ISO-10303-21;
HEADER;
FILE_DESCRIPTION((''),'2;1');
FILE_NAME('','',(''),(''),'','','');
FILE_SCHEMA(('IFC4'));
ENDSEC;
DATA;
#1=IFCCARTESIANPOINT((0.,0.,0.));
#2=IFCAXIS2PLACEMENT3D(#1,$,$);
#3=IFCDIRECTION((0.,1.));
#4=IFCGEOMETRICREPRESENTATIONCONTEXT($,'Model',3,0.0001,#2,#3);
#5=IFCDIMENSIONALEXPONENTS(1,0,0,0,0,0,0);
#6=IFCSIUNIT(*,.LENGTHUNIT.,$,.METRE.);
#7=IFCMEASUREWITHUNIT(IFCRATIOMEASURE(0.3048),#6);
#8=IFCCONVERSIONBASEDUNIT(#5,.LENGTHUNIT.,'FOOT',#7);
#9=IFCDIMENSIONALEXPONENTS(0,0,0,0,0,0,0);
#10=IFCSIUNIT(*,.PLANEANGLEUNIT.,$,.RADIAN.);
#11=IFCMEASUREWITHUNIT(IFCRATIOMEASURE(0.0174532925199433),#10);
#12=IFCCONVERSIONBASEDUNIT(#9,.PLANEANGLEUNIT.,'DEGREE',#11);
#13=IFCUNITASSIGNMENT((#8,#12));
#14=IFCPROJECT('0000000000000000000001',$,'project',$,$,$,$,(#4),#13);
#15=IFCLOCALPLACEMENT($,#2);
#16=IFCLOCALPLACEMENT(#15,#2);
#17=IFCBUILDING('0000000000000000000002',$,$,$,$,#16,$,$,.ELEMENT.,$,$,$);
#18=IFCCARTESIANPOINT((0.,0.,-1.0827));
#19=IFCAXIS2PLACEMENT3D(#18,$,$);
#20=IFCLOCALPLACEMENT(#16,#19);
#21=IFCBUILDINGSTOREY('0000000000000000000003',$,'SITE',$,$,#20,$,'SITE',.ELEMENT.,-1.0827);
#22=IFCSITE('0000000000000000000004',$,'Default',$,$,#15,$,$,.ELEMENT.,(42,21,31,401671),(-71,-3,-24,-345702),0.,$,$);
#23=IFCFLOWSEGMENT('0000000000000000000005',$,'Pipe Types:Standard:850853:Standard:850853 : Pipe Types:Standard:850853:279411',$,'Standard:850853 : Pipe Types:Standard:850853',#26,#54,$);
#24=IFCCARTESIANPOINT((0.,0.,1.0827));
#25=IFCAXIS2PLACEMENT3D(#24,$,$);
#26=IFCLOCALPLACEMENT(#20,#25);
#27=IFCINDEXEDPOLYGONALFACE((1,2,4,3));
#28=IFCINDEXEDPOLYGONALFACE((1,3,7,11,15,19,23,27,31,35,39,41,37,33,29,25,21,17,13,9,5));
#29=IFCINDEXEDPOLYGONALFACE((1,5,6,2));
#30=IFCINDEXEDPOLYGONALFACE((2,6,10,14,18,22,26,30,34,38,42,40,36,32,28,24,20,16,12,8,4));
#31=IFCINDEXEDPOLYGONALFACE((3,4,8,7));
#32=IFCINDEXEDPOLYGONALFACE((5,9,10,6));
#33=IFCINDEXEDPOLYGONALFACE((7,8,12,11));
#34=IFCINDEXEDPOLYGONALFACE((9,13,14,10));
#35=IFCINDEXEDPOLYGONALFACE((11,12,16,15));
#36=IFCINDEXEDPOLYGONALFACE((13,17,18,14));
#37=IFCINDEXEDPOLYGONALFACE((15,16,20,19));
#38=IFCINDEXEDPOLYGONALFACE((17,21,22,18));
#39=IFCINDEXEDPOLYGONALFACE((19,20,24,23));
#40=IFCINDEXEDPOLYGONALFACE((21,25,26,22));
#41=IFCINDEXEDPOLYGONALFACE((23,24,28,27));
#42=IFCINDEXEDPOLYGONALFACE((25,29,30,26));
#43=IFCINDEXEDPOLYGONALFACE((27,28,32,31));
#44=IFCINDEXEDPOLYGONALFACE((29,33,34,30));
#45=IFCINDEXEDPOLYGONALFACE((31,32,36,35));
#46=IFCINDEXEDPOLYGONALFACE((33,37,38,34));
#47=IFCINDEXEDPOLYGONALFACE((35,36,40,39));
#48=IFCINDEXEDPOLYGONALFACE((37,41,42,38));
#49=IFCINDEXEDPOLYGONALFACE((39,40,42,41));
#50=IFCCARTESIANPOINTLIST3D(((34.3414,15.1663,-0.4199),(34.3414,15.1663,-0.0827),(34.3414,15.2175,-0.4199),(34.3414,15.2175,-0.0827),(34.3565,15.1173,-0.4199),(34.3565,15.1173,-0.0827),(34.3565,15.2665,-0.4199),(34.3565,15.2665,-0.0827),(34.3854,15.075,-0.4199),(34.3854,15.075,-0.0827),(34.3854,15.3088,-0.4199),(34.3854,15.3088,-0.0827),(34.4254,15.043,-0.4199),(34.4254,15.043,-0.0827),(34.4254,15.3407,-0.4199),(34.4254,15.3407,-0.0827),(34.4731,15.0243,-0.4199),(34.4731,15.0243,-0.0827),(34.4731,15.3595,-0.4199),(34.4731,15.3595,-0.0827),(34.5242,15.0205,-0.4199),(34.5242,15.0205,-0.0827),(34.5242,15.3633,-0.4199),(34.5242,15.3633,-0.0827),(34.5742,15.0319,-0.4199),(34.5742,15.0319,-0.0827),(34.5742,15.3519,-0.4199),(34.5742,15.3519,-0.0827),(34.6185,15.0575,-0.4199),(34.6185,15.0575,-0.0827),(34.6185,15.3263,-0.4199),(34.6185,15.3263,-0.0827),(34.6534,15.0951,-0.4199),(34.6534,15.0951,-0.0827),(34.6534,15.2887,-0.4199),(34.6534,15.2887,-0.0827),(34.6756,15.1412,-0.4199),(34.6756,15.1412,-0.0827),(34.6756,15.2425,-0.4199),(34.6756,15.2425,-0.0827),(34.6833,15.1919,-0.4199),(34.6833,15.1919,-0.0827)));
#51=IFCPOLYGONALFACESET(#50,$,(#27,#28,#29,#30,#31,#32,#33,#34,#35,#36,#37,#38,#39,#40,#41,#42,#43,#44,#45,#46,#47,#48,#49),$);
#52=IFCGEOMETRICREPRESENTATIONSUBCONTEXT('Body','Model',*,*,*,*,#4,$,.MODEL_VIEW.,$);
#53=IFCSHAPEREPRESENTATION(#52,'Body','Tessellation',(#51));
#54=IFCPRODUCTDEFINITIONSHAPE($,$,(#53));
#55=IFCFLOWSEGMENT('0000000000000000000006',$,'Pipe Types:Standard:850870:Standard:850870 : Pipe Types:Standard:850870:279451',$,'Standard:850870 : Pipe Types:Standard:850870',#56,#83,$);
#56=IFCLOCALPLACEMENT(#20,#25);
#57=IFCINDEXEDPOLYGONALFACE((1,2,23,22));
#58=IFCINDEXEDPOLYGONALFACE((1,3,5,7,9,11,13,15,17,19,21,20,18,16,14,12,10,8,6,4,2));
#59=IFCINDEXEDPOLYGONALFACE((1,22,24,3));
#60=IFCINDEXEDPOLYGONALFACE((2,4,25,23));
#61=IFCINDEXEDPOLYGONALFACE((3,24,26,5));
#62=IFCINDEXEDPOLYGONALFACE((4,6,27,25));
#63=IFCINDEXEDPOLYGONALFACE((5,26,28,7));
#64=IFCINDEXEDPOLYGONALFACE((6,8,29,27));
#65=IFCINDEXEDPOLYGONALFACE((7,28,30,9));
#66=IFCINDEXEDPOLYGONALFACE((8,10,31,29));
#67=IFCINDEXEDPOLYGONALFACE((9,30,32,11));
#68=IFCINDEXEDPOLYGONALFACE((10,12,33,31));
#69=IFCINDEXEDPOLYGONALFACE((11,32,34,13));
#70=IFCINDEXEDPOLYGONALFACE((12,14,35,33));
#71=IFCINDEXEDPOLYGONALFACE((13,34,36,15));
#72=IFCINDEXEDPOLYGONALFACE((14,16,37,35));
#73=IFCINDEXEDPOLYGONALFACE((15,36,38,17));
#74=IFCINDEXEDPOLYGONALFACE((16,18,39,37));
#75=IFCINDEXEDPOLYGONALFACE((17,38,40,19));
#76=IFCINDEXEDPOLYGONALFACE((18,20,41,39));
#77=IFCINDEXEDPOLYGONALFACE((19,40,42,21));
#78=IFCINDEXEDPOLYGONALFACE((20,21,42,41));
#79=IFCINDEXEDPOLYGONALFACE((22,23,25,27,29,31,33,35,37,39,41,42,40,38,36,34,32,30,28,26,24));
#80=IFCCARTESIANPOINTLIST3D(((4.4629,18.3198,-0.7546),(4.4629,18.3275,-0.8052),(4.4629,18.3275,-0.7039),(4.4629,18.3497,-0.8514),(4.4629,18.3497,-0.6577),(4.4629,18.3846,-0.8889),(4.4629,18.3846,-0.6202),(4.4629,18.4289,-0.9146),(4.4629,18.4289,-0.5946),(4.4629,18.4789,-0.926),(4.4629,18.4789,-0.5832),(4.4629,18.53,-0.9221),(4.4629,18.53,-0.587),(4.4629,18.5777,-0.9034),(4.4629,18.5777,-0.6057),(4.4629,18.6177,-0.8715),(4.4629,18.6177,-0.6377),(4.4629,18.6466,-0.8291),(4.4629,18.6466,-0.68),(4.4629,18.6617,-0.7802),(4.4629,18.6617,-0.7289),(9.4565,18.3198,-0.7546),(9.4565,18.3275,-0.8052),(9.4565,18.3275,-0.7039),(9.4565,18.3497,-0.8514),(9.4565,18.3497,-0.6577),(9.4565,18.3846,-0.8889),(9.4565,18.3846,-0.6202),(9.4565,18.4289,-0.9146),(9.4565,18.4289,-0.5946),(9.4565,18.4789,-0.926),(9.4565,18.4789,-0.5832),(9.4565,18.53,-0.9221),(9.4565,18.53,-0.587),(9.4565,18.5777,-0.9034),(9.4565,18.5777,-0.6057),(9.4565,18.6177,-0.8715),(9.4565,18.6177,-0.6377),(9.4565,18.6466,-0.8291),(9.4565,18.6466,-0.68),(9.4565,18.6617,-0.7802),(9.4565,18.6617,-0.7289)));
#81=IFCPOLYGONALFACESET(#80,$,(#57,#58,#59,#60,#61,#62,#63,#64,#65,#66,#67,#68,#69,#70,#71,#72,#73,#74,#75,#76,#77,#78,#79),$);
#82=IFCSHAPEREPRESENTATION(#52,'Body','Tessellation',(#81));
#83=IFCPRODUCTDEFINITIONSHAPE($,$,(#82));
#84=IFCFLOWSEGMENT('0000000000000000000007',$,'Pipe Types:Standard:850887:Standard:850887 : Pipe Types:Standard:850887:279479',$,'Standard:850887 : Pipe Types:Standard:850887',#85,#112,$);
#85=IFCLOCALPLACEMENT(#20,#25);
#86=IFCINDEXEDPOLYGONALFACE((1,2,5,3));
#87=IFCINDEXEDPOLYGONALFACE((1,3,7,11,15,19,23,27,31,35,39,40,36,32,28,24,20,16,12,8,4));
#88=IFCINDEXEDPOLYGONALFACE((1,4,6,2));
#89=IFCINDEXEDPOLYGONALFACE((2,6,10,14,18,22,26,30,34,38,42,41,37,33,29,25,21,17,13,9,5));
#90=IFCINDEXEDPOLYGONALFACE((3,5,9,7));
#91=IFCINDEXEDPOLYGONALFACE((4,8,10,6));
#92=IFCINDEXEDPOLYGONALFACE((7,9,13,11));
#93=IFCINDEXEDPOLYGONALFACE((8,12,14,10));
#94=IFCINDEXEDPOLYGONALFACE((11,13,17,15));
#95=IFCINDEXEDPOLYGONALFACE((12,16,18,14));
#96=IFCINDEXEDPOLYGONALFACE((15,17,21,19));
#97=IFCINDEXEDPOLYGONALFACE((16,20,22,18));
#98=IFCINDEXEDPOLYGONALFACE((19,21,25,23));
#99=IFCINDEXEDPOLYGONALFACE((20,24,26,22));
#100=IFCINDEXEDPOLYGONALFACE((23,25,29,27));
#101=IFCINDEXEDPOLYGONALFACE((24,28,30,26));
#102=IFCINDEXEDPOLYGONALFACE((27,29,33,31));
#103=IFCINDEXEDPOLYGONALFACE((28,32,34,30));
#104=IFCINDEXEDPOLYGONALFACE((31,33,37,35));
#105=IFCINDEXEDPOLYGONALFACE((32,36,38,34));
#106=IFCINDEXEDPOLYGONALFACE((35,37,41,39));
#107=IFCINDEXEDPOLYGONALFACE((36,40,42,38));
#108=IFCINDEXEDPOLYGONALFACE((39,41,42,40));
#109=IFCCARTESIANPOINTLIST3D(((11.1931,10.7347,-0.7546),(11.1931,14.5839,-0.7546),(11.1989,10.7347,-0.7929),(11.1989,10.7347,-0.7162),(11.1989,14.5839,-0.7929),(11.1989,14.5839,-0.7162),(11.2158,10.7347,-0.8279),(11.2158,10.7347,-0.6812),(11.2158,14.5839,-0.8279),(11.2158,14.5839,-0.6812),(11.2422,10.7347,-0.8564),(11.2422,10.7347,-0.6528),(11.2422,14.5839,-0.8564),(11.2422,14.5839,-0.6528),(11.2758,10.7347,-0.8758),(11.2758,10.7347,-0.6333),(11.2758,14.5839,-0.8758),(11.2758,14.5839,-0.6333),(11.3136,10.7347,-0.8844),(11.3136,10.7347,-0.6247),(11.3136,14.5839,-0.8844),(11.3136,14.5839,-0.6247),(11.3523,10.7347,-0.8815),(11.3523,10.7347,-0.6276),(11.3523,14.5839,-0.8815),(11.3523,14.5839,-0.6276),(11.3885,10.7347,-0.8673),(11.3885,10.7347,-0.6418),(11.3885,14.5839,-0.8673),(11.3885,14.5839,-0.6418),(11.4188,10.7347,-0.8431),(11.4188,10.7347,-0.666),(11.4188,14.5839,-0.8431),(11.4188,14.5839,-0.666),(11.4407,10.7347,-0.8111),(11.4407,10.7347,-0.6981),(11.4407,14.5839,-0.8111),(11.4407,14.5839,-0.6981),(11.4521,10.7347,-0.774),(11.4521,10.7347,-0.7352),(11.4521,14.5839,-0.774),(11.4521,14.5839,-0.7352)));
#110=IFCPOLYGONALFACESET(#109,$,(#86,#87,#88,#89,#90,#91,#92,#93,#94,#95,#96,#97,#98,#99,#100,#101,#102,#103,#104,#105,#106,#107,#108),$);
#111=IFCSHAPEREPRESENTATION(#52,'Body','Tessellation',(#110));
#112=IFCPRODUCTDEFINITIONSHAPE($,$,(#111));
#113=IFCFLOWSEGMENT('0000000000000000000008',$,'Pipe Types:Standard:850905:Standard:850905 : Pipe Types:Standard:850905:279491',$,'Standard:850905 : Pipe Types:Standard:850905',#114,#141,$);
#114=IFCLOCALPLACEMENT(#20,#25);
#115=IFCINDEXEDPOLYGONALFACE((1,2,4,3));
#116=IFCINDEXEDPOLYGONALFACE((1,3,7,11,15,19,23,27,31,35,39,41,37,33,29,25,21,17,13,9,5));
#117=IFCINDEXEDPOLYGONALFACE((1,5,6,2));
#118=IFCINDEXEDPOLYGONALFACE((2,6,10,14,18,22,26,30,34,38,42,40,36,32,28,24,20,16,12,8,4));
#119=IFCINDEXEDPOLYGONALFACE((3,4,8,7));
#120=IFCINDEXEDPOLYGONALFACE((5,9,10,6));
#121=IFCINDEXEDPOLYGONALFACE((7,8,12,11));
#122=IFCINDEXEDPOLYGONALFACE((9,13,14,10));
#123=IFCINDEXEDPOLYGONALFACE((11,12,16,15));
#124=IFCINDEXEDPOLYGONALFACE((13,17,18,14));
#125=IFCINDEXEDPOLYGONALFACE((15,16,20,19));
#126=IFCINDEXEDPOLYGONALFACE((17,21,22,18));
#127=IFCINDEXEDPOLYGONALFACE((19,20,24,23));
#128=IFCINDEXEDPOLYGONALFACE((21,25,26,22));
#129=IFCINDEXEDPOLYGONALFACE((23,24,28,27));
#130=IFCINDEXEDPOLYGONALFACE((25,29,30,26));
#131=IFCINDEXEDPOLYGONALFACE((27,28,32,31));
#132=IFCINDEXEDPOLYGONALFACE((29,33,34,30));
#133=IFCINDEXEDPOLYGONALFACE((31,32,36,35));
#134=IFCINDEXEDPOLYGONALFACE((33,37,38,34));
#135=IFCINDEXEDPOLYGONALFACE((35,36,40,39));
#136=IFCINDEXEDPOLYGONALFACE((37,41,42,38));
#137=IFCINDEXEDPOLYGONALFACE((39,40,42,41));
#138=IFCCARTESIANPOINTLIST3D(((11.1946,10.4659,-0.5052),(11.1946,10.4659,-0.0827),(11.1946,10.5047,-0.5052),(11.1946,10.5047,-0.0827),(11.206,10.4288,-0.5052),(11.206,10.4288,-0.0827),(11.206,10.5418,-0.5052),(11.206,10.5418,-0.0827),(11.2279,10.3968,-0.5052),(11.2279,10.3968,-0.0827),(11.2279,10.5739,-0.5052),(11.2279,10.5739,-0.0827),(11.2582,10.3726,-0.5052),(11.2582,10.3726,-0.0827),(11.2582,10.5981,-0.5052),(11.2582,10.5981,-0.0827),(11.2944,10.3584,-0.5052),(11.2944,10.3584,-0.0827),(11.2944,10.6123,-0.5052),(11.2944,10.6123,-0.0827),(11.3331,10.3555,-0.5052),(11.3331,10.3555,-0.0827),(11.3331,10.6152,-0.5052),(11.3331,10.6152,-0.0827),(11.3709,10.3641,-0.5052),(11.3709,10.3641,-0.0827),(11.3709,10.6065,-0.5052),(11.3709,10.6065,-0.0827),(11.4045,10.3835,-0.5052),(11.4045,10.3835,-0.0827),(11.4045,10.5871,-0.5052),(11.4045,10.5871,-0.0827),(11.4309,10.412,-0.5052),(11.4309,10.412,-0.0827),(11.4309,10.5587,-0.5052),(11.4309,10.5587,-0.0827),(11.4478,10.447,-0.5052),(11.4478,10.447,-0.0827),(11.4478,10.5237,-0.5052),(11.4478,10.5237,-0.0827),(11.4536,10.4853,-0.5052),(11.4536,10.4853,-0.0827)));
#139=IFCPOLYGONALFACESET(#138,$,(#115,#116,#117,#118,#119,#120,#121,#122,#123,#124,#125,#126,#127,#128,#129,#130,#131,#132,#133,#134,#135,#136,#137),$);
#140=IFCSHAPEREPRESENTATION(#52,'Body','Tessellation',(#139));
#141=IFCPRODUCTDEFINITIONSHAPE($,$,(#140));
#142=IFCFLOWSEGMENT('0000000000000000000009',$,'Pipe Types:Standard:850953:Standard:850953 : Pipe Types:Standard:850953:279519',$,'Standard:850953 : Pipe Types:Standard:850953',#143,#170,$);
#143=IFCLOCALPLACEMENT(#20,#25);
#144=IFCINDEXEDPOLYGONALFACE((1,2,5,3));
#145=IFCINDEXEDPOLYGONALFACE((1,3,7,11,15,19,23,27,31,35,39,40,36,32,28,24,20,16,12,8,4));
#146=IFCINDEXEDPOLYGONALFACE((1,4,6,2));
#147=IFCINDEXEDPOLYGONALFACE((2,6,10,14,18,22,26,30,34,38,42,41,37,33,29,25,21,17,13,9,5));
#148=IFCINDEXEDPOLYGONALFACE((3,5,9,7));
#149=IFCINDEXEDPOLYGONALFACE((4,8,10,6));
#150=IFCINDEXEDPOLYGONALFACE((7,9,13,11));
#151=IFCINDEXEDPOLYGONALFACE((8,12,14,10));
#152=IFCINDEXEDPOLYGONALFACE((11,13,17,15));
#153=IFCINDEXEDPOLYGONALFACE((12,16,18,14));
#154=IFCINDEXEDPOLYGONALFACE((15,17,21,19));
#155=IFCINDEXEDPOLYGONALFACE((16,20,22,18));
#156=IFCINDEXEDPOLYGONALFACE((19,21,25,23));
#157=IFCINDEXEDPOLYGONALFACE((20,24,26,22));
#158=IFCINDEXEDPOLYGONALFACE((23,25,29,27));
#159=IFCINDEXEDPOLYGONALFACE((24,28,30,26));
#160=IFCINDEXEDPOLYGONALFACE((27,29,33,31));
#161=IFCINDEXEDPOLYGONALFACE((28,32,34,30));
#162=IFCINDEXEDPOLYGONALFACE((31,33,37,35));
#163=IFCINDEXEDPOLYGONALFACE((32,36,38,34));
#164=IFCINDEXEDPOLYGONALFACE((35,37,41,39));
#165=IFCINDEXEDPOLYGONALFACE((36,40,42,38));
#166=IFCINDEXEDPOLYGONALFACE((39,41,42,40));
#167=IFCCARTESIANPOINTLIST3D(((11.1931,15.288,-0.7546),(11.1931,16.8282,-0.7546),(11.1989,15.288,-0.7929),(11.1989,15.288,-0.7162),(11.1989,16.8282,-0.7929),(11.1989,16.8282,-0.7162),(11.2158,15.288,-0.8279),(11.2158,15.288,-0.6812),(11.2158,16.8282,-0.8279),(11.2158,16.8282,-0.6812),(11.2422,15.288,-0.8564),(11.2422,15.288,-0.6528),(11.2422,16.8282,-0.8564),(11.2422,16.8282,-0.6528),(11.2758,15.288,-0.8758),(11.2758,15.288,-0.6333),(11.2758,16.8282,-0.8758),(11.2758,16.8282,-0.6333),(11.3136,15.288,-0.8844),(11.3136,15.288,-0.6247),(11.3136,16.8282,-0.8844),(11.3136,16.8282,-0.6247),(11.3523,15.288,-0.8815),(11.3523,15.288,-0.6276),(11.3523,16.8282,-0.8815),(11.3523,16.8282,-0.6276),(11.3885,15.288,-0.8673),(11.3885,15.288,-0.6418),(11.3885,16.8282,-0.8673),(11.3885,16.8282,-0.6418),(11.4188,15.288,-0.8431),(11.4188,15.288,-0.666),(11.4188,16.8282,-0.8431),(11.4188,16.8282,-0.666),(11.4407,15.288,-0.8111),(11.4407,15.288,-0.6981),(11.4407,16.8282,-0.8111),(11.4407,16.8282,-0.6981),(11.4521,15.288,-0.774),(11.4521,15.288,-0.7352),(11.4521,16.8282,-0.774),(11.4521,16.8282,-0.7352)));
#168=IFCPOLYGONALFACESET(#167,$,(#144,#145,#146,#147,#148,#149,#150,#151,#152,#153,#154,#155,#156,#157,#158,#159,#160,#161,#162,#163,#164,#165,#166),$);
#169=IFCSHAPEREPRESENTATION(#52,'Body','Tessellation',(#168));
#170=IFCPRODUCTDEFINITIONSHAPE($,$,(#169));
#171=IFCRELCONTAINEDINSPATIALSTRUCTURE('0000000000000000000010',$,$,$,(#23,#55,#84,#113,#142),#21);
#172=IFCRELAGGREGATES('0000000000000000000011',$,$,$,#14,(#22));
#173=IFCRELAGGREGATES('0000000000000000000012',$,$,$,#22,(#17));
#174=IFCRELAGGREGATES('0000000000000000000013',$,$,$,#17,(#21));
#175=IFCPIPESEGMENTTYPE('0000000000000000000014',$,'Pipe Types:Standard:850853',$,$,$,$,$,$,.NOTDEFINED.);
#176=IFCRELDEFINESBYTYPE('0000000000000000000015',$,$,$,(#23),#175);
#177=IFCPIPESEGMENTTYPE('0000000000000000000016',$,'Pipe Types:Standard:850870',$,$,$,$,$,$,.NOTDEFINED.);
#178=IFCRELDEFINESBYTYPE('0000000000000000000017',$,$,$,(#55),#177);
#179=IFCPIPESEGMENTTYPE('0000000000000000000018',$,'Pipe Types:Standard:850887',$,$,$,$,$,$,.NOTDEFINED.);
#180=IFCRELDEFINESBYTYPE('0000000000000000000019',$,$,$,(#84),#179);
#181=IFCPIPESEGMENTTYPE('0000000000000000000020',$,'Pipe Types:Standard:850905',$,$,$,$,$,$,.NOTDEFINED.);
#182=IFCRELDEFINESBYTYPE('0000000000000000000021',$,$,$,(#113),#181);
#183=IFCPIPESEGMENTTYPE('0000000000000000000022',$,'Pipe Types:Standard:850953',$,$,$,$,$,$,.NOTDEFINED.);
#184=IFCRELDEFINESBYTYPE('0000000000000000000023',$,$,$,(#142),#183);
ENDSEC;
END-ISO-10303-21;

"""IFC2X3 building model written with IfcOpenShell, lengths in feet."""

from ifc_helpers import new_model, entity, si_unit, converted_unit, direction, frame, frame_2d, origin, origin_2d_with_axis, place, context, subcontext, project, spatial, circle, extrude, source, transform, mapped, type_object, type_shapes, element, save


model = new_model("IFC2X3")

# Units and contexts
model_context = context("Model", 3, precision=0.0001, world=origin(), true_north=direction((0.0, 1.0)))
body_context = subcontext(model_context, "Body", "Model", "MODEL_VIEW")
ifc_project = project(units=[converted_unit("LENGTHUNIT", "FOOT", entity("IfcRatioMeasure", 0.3048), si_unit("LENGTHUNIT", "METRE"), dimensions=[1, 0, 0, 0, 0, 0, 0]), converted_unit("PLANEANGLEUNIT", "DEGREE", entity("IfcRatioMeasure", 0.0174532925199433), si_unit("PLANEANGLEUNIT", "RADIAN"), dimensions=[0, 0, 0, 0, 0, 0, 0])], contexts=[model_context])

# Site, building, storey
site_placement = place(None, origin())
site = spatial("IfcSite", under=ifc_project, at=site_placement, Name="Default", CompositionType="ELEMENT", RefLatitude=(42, 21, 31, 401671), RefLongitude=(-71, -3, -24, -345702), RefElevation=0.0)
building_placement = place(site_placement, origin())
building = spatial("IfcBuilding", under=site, at=building_placement, CompositionType="ELEMENT")
storey_placement = place(building_placement, frame((0.0, 0.0, -1.0827)))
storey = spatial("IfcBuildingStorey", under=building, at=storey_placement, Name="SITE", LongName="SITE", CompositionType="ELEMENT", Elevation=-1.0827)

# Flow segments
pipe_segment_type_1 = type_object("IfcPipeSegmentType", Name="Pipe Types:Standard:850853", PredefinedType="NOTDEFINED")
shared_shape_1 = source(origin(), body_context, "Body", "SweptSolid", [
    extrude(circle(Radius=0.1719, at=origin_2d_with_axis()), frame((34.5114, 15.1919, -0.4199)), (0.0, 0.0, 1.0), 0.3372),
])
type_shapes(pipe_segment_type_1, [shared_shape_1])
flow_segment_1_placement = place(storey_placement, frame((0.0, 0.0, 1.0827)))
element("IfcFlowSegment", 1, at=flow_segment_1_placement, inside=storey, type_object=pipe_segment_type_1, Name="Pipe Types:Standard:850853:Standard:850853 : Pipe Types:Standard:850853:279411", ObjectType="Standard:850853 : Pipe Types:Standard:850853", context=body_context, shape_type="MappedRepresentation", body=[
    mapped(shared_shape_1, transform((0.0, 0.0, 0.0), scale=1.0)),
])
pipe_segment_type_2 = type_object("IfcPipeSegmentType", Name="Pipe Types:Standard:850870", PredefinedType="NOTDEFINED")
shared_shape_2 = source(origin(), body_context, "Body", "SweptSolid", [
    extrude(circle(Radius=0.1719, at=frame_2d((0.0, 0.0), x_axis=(1.0, 0.0))), frame((4.4629, 18.4917, -0.7546), z_axis=(1.0, 0.0, 0.0), x_axis=(0.0, -1.0, 0.0)), (0.0, 0.0, 1.0), 4.9936),
])
type_shapes(pipe_segment_type_2, [shared_shape_2])
flow_segment_2_placement = place(storey_placement, frame((0.0, 0.0, 1.0827)))
element("IfcFlowSegment", 2, at=flow_segment_2_placement, inside=storey, type_object=pipe_segment_type_2, Name="Pipe Types:Standard:850870:Standard:850870 : Pipe Types:Standard:850870:279451", ObjectType="Standard:850870 : Pipe Types:Standard:850870", context=body_context, shape_type="MappedRepresentation", body=[
    mapped(shared_shape_2, transform((0.0, 0.0, 0.0), scale=1.0)),
])
pipe_segment_type_3 = type_object("IfcPipeSegmentType", Name="Pipe Types:Standard:850887", PredefinedType="NOTDEFINED")
shared_shape_3 = source(origin(), body_context, "Body", "SweptSolid", [
    extrude(circle(Radius=0.1302, at=frame_2d((0.0, 0.0), x_axis=(1.0, 0.0))), frame((11.3233, 10.7347, -0.7546), z_axis=(0.0, 1.0, 0.0), x_axis=(-1.0, 0.0, 0.0)), (0.0, 0.0, 1.0), 3.8492),
])
type_shapes(pipe_segment_type_3, [shared_shape_3])
flow_segment_3_placement = place(storey_placement, frame((0.0, 0.0, 1.0827)))
element("IfcFlowSegment", 3, at=flow_segment_3_placement, inside=storey, type_object=pipe_segment_type_3, Name="Pipe Types:Standard:850887:Standard:850887 : Pipe Types:Standard:850887:279479", ObjectType="Standard:850887 : Pipe Types:Standard:850887", context=body_context, shape_type="MappedRepresentation", body=[
    mapped(shared_shape_3, transform((0.0, 0.0, 0.0), scale=1.0)),
])
pipe_segment_type_4 = type_object("IfcPipeSegmentType", Name="Pipe Types:Standard:850905", PredefinedType="NOTDEFINED")
shared_shape_4 = source(origin(), body_context, "Body", "SweptSolid", [
    extrude(circle(Radius=0.1302, at=origin_2d_with_axis()), frame((11.3233, 10.4853, -0.5052)), (0.0, 0.0, 1.0), 0.4225),
])
type_shapes(pipe_segment_type_4, [shared_shape_4])
flow_segment_4_placement = place(storey_placement, frame((0.0, 0.0, 1.0827)))
element("IfcFlowSegment", 4, at=flow_segment_4_placement, inside=storey, type_object=pipe_segment_type_4, Name="Pipe Types:Standard:850905:Standard:850905 : Pipe Types:Standard:850905:279491", ObjectType="Standard:850905 : Pipe Types:Standard:850905", context=body_context, shape_type="MappedRepresentation", body=[
    mapped(shared_shape_4, transform((0.0, 0.0, 0.0), scale=1.0)),
])
pipe_segment_type_5 = type_object("IfcPipeSegmentType", Name="Pipe Types:Standard:850953", PredefinedType="NOTDEFINED")
shared_shape_5 = source(origin(), body_context, "Body", "SweptSolid", [
    extrude(circle(Radius=0.1302, at=frame_2d((0.0, 0.0), x_axis=(1.0, 0.0))), frame((11.3233, 15.288, -0.7546), z_axis=(0.0, 1.0, 0.0), x_axis=(-1.0, 0.0, 0.0)), (0.0, 0.0, 1.0), 1.5401),
])
type_shapes(pipe_segment_type_5, [shared_shape_5])
flow_segment_5_placement = place(storey_placement, frame((0.0, 0.0, 1.0827)))
element("IfcFlowSegment", 5, at=flow_segment_5_placement, inside=storey, type_object=pipe_segment_type_5, Name="Pipe Types:Standard:850953:Standard:850953 : Pipe Types:Standard:850953:279519", ObjectType="Standard:850953 : Pipe Types:Standard:850953", context=body_context, shape_type="MappedRepresentation", body=[
    mapped(shared_shape_5, transform((0.0, 0.0, 0.0), scale=1.0)),
])

save(model, "model.ifc")
